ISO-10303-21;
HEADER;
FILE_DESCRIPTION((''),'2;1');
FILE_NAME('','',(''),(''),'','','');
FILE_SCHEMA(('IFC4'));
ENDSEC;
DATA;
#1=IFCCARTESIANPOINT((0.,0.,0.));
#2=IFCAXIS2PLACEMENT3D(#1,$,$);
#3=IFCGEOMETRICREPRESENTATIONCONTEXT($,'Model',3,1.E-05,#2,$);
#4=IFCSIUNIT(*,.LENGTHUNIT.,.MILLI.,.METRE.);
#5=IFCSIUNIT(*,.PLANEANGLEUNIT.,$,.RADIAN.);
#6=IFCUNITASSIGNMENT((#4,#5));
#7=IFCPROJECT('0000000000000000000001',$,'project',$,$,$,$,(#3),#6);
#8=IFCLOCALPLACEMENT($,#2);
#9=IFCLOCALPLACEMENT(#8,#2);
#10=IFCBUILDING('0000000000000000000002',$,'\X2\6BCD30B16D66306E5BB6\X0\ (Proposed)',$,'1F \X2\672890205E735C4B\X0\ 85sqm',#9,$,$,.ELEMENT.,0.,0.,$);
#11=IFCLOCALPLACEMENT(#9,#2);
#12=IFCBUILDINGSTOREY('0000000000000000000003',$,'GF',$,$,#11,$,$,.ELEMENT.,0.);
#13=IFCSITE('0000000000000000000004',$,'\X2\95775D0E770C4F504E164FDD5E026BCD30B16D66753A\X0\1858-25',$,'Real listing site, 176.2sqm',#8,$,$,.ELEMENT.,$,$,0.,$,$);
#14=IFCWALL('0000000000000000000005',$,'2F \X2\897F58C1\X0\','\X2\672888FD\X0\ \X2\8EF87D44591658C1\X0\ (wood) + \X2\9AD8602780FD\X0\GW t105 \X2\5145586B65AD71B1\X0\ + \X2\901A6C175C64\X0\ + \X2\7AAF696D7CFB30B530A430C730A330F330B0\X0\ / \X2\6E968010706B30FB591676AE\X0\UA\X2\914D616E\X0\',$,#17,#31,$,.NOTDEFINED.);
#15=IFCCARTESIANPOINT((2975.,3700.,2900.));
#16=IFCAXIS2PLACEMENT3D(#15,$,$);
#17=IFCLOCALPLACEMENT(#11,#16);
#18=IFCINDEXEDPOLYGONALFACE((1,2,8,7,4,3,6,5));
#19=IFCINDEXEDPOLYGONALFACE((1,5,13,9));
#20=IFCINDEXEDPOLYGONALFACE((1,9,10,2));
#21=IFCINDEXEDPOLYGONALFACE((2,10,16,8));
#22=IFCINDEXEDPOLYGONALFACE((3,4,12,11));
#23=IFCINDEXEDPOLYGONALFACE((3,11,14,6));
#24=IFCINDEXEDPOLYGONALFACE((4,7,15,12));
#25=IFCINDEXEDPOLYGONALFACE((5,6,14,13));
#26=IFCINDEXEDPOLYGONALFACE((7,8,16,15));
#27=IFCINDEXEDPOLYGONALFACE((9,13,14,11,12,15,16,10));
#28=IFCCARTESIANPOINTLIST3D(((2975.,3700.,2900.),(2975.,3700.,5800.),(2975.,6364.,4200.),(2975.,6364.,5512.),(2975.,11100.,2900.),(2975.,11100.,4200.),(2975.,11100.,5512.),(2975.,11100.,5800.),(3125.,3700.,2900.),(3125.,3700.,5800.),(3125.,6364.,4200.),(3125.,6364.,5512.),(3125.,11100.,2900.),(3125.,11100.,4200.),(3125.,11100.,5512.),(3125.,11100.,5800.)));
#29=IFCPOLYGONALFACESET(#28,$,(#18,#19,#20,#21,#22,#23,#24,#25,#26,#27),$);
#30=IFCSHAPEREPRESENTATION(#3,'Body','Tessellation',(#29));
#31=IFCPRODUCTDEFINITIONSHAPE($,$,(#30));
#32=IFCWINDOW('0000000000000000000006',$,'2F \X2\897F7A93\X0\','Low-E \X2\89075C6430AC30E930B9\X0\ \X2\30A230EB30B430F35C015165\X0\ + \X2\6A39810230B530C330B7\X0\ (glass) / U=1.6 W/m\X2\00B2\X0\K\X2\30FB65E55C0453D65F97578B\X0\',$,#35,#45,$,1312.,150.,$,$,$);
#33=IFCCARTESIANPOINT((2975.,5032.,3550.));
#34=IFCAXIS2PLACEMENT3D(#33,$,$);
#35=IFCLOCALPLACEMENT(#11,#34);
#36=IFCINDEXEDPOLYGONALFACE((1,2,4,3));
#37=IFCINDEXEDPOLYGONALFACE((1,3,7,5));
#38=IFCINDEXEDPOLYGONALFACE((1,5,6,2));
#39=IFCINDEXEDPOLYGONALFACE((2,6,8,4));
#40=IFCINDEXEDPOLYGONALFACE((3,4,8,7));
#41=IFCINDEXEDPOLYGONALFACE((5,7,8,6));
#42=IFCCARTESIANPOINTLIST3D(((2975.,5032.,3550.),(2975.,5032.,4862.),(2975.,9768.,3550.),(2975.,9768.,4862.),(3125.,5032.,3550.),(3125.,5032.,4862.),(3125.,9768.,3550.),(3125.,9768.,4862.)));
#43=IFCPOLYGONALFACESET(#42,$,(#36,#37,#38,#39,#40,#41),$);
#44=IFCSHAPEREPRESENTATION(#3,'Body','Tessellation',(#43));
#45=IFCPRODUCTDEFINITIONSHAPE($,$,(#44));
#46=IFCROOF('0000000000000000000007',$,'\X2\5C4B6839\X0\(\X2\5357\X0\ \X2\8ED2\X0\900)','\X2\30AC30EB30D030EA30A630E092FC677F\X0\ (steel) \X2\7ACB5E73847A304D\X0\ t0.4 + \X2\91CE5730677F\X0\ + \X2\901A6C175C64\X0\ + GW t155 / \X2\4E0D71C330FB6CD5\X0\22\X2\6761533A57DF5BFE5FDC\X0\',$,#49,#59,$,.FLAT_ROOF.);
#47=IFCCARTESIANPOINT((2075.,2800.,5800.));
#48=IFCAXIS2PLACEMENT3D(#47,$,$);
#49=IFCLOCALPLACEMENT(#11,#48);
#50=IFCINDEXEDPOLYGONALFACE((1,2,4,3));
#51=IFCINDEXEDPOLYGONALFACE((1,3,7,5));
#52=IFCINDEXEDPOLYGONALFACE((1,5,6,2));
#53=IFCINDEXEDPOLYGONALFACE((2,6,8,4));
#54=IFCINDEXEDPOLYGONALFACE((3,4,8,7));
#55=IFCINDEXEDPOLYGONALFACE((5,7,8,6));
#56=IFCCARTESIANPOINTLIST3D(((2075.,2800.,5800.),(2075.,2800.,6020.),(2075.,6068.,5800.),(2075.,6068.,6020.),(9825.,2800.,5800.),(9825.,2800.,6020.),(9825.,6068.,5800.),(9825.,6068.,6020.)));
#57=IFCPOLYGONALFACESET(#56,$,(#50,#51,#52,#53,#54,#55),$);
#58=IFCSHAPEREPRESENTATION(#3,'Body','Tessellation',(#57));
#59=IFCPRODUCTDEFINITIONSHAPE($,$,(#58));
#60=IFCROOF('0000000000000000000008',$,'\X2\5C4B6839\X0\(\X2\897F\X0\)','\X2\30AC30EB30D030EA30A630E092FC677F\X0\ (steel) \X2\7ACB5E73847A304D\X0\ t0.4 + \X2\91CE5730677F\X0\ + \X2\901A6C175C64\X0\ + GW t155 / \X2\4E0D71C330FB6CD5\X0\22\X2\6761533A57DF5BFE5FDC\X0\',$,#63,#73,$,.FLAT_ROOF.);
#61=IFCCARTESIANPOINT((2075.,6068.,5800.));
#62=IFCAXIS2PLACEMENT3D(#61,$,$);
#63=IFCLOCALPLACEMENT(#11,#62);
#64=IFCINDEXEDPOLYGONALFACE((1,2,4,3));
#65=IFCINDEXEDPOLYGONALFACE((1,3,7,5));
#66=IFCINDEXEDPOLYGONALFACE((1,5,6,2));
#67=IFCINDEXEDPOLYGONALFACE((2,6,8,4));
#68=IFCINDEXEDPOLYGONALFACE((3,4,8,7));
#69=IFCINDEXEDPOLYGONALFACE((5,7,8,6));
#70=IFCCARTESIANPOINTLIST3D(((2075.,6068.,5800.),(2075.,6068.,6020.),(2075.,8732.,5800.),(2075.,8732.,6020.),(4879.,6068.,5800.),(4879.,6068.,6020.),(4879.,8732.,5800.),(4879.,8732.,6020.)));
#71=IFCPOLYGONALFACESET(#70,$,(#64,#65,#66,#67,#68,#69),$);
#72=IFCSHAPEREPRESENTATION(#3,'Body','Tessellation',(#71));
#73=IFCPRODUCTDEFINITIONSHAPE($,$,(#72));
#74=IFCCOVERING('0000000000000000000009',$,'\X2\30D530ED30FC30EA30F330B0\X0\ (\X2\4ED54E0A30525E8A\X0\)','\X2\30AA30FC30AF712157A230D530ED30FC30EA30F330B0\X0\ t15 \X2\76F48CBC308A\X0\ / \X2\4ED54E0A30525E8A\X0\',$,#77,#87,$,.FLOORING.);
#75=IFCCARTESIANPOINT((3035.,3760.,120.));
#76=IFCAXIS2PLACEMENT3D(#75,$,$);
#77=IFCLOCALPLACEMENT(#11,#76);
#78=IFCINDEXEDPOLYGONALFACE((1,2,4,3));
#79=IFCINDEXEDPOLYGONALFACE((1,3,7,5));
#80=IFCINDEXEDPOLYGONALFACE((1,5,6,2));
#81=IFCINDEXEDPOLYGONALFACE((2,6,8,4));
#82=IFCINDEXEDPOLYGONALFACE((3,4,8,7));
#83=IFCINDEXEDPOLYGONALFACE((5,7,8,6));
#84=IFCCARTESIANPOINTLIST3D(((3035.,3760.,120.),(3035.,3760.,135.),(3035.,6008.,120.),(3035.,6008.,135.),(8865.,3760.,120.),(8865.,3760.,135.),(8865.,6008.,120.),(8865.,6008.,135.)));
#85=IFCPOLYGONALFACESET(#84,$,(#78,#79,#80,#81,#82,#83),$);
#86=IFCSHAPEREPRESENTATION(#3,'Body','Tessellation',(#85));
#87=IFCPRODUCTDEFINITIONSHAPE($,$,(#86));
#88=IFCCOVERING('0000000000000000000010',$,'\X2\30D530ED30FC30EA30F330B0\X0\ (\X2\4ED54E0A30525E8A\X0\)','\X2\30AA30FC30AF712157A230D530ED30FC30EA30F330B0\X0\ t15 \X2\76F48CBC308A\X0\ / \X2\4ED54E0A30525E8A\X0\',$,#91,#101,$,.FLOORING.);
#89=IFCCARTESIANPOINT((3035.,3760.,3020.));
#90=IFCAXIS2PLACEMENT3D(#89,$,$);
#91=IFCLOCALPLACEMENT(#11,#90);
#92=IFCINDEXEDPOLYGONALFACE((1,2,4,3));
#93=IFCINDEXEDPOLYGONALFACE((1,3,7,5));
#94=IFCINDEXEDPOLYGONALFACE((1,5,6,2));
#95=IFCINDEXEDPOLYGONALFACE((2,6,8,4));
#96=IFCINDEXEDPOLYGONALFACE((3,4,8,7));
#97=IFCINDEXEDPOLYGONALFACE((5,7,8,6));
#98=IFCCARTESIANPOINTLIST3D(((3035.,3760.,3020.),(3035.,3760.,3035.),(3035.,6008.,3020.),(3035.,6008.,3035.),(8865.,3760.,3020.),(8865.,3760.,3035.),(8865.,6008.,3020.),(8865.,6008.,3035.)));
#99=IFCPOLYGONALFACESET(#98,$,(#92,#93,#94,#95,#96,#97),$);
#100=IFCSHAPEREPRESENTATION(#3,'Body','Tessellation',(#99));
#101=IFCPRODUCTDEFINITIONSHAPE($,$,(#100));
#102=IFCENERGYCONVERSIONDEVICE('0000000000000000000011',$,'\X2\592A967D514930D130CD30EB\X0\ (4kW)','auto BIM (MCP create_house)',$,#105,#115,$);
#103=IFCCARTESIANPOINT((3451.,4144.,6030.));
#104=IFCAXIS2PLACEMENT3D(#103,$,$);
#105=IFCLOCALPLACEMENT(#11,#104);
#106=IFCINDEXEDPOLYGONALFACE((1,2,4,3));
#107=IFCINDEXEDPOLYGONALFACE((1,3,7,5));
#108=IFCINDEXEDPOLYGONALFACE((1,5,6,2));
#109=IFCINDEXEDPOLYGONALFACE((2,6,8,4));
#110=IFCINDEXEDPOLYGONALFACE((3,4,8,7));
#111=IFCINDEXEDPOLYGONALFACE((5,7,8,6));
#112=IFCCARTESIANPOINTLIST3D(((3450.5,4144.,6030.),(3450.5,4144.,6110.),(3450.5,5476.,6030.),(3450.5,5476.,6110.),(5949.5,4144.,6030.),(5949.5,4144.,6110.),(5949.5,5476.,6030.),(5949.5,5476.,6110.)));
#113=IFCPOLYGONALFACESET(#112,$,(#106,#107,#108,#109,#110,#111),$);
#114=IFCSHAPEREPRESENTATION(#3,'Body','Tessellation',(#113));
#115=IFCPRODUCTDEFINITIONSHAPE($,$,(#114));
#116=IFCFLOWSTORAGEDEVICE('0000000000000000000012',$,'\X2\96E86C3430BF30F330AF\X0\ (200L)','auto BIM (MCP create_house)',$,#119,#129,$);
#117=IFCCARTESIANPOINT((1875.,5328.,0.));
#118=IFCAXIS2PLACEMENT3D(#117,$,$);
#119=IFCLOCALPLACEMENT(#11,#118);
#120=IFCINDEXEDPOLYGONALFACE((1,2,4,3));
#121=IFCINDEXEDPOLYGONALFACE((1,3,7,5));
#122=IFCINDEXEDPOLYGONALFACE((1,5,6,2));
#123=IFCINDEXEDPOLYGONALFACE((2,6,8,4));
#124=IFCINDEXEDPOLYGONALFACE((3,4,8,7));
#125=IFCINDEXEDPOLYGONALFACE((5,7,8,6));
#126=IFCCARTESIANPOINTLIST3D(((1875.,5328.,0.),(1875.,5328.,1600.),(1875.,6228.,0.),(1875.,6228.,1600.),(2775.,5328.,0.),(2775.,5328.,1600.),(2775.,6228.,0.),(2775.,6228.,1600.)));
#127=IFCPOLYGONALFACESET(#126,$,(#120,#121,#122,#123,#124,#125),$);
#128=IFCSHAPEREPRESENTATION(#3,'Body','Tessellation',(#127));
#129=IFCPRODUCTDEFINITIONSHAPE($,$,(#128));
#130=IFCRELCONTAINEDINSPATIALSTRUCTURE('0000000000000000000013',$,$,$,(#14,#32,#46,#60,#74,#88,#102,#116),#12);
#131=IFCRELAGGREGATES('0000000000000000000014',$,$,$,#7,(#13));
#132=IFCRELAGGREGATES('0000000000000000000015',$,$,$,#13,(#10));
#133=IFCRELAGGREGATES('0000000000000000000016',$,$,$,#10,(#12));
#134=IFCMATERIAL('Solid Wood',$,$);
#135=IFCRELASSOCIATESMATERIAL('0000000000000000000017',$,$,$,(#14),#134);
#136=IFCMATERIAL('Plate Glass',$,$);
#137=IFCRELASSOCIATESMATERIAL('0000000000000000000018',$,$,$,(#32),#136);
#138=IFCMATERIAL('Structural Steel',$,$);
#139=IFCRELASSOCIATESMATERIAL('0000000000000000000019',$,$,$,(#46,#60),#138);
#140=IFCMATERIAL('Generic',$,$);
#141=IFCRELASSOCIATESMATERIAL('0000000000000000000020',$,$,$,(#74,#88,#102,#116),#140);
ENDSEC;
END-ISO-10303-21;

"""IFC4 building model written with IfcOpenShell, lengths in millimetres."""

from ifc_helpers import new_model, si_unit, frame, frame_2d, origin, place, context, project, spatial, rectangle, extrude, material, element, fill, save


model = new_model("IFC4")

# Units and contexts
model_context = context("Model", 3, precision=1e-05, world=origin())
ifc_project = project(units=[si_unit("LENGTHUNIT", "METRE", prefix="MILLI"), si_unit("PLANEANGLEUNIT", "RADIAN")], contexts=[model_context])

# Site, building, storey
site_placement = place(None, origin())
site = spatial("IfcSite", under=ifc_project, at=site_placement, Name="長崎県佐世保市母ケ浦町1858-25", ObjectType="Real listing site, 176.2sqm", CompositionType="ELEMENT", RefElevation=0.0)
building_placement = place(site_placement, origin())
building = spatial("IfcBuilding", under=site, at=building_placement, Name="母ケ浦の家 (Proposed)", ObjectType="1F 木造平屋 85sqm", CompositionType="ELEMENT", ElevationOfRefHeight=0.0, ElevationOfTerrain=0.0)
storey_placement = place(building_placement, origin())
storey = spatial("IfcBuildingStorey", under=building, at=storey_placement, Name="GF", CompositionType="ELEMENT", Elevation=0.0)

# Shared definitions
ifc_material_1 = material(Name="Solid Wood")
ifc_material_2 = material(Name="Generic")

# Shared definitions
ifc_material_3 = material(Name="Plate Glass")

# Wall, opening, window
wall_1_placement = place(storey_placement, frame((2975.0, 3700.0, 2900.0)))
wall_1 = element("IfcWall", 1, at=wall_1_placement, inside=storey, material=ifc_material_1, Name="2F 西壁", Description="木製 軸組外壁 (wood) + 高性能GW t105 充填断熱 + 通気層 + 窯業系サイディング / 準耐火・外皮UA配慮", PredefinedType="NOTDEFINED", context=model_context, shape_type="SweptSolid", body=[
    extrude(rectangle(XDim=150.0, YDim=7400.0, at=frame_2d((75.0, 3700.0))), frame((2975.0, 3700.0, 2900.0)), (0.0, 0.0, 1.0), 2900.0),
])
opening_1_placement = place(storey_placement, frame((2975.0, 5032.0, 3550.0)))
opening_1 = element("IfcOpeningElement", 2, at=opening_1_placement, cuts=wall_1, PredefinedType="NOTDEFINED", context=model_context, shape_type="SweptSolid", body=[
    extrude(rectangle(XDim=150.0, YDim=4736.0, at=frame_2d((75.0, 2368.0))), frame((2975.0, 5032.0, 3550.0)), (0.0, 0.0, 1.0), 1312.0),
])
window_1_placement = place(storey_placement, frame((2975.0, 5032.0, 3550.0)))
window_1 = element("IfcWindow", 3, at=window_1_placement, inside=storey, material=ifc_material_3, Name="2F 西窓", Description="Low-E 複層ガラス アルゴン封入 + 樹脂サッシ (glass) / U=1.6 W/m²K・日射取得型", OverallHeight=1312.0, OverallWidth=150.0, context=model_context, shape_type="SweptSolid", body=[
    extrude(rectangle(XDim=150.0, YDim=4736.0, at=frame_2d((75.0, 2368.0))), frame((2975.0, 5032.0, 3550.0)), (0.0, 0.0, 1.0), 1312.0),
])
fill(opening_1, window_1)

# Roofs
ifc_material_4 = material(Name="Structural Steel")
roof_1_placement = place(storey_placement, frame((2075.0, 2800.0, 5800.0)))
element("IfcRoof", 4, at=roof_1_placement, inside=storey, material=ifc_material_4, Name="屋根(南 軒900)", Description="ガルバリウム鋼板 (steel) 立平葺き t0.4 + 野地板 + 通気層 + GW t155 / 不燃・法22条区域対応", PredefinedType="FLAT_ROOF", context=model_context, shape_type="SweptSolid", body=[
    extrude(rectangle(XDim=7750.0, YDim=3268.0, at=frame_2d((3875.0, 1634.0))), frame((2075.0, 2800.0, 5800.0)), (0.0, 0.0, 1.0), 220.0),
])
roof_2_placement = place(storey_placement, frame((2075.0, 6068.0, 5800.0)))
element("IfcRoof", 5, at=roof_2_placement, inside=storey, material=ifc_material_4, Name="屋根(西)", Description="ガルバリウム鋼板 (steel) 立平葺き t0.4 + 野地板 + 通気層 + GW t155 / 不燃・法22条区域対応", PredefinedType="FLAT_ROOF", context=model_context, shape_type="SweptSolid", body=[
    extrude(rectangle(XDim=2804.0, YDim=2664.0, at=frame_2d((1402.0, 1332.0))), frame((2075.0, 6068.0, 5800.0)), (0.0, 0.0, 1.0), 220.0),
])

# Coverings
covering_1_placement = place(storey_placement, frame((3035.0, 3760.0, 120.0)))
element("IfcCovering", 6, at=covering_1_placement, inside=storey, material=ifc_material_2, Name="フローリング (仕上げ床)", Description="オーク無垢フローリング t15 直貼り / 仕上げ床", PredefinedType="FLOORING", context=model_context, shape_type="SweptSolid", body=[
    extrude(rectangle(XDim=5830.0, YDim=2248.0, at=frame_2d((2915.0, 1124.0))), frame((3035.0, 3760.0, 120.0)), (0.0, 0.0, 1.0), 15.0),
])
covering_2_placement = place(storey_placement, frame((3035.0, 3760.0, 3020.0)))
element("IfcCovering", 7, at=covering_2_placement, inside=storey, material=ifc_material_2, Name="フローリング (仕上げ床)", Description="オーク無垢フローリング t15 直貼り / 仕上げ床", PredefinedType="FLOORING", context=model_context, shape_type="SweptSolid", body=[
    extrude(rectangle(XDim=5830.0, YDim=2248.0, at=frame_2d((2915.0, 1124.0))), frame((3035.0, 3760.0, 3020.0)), (0.0, 0.0, 1.0), 15.0),
])

# Energy conversion device
energy_conversion_device_placement = place(storey_placement, frame((3451.0, 4144.0, 6030.0)))
element("IfcEnergyConversionDevice", 8, at=energy_conversion_device_placement, inside=storey, material=ifc_material_2, Name="太陽光パネル (4kW)", Description="auto BIM (MCP create_house)", context=model_context, shape_type="SweptSolid", body=[
    extrude(rectangle(XDim=2499.0, YDim=1332.0, at=frame_2d((1249.0, 666.0))), frame((3451.0, 4144.0, 6030.0)), (0.0, 0.0, 1.0), 80.0),
])

# Flow storage device
flow_storage_device_placement = place(storey_placement, frame((1875.0, 5328.0, 0.0)))
element("IfcFlowStorageDevice", 9, at=flow_storage_device_placement, inside=storey, material=ifc_material_2, Name="雨水タンク (200L)", Description="auto BIM (MCP create_house)", context=model_context, shape_type="SweptSolid", body=[
    extrude(rectangle(XDim=900.0, YDim=900.0, at=frame_2d((450.0, 450.0))), frame((1875.0, 5328.0, 0.0)), (0.0, 0.0, 1.0), 1600.0),
])

save(model, "model.ifc")
